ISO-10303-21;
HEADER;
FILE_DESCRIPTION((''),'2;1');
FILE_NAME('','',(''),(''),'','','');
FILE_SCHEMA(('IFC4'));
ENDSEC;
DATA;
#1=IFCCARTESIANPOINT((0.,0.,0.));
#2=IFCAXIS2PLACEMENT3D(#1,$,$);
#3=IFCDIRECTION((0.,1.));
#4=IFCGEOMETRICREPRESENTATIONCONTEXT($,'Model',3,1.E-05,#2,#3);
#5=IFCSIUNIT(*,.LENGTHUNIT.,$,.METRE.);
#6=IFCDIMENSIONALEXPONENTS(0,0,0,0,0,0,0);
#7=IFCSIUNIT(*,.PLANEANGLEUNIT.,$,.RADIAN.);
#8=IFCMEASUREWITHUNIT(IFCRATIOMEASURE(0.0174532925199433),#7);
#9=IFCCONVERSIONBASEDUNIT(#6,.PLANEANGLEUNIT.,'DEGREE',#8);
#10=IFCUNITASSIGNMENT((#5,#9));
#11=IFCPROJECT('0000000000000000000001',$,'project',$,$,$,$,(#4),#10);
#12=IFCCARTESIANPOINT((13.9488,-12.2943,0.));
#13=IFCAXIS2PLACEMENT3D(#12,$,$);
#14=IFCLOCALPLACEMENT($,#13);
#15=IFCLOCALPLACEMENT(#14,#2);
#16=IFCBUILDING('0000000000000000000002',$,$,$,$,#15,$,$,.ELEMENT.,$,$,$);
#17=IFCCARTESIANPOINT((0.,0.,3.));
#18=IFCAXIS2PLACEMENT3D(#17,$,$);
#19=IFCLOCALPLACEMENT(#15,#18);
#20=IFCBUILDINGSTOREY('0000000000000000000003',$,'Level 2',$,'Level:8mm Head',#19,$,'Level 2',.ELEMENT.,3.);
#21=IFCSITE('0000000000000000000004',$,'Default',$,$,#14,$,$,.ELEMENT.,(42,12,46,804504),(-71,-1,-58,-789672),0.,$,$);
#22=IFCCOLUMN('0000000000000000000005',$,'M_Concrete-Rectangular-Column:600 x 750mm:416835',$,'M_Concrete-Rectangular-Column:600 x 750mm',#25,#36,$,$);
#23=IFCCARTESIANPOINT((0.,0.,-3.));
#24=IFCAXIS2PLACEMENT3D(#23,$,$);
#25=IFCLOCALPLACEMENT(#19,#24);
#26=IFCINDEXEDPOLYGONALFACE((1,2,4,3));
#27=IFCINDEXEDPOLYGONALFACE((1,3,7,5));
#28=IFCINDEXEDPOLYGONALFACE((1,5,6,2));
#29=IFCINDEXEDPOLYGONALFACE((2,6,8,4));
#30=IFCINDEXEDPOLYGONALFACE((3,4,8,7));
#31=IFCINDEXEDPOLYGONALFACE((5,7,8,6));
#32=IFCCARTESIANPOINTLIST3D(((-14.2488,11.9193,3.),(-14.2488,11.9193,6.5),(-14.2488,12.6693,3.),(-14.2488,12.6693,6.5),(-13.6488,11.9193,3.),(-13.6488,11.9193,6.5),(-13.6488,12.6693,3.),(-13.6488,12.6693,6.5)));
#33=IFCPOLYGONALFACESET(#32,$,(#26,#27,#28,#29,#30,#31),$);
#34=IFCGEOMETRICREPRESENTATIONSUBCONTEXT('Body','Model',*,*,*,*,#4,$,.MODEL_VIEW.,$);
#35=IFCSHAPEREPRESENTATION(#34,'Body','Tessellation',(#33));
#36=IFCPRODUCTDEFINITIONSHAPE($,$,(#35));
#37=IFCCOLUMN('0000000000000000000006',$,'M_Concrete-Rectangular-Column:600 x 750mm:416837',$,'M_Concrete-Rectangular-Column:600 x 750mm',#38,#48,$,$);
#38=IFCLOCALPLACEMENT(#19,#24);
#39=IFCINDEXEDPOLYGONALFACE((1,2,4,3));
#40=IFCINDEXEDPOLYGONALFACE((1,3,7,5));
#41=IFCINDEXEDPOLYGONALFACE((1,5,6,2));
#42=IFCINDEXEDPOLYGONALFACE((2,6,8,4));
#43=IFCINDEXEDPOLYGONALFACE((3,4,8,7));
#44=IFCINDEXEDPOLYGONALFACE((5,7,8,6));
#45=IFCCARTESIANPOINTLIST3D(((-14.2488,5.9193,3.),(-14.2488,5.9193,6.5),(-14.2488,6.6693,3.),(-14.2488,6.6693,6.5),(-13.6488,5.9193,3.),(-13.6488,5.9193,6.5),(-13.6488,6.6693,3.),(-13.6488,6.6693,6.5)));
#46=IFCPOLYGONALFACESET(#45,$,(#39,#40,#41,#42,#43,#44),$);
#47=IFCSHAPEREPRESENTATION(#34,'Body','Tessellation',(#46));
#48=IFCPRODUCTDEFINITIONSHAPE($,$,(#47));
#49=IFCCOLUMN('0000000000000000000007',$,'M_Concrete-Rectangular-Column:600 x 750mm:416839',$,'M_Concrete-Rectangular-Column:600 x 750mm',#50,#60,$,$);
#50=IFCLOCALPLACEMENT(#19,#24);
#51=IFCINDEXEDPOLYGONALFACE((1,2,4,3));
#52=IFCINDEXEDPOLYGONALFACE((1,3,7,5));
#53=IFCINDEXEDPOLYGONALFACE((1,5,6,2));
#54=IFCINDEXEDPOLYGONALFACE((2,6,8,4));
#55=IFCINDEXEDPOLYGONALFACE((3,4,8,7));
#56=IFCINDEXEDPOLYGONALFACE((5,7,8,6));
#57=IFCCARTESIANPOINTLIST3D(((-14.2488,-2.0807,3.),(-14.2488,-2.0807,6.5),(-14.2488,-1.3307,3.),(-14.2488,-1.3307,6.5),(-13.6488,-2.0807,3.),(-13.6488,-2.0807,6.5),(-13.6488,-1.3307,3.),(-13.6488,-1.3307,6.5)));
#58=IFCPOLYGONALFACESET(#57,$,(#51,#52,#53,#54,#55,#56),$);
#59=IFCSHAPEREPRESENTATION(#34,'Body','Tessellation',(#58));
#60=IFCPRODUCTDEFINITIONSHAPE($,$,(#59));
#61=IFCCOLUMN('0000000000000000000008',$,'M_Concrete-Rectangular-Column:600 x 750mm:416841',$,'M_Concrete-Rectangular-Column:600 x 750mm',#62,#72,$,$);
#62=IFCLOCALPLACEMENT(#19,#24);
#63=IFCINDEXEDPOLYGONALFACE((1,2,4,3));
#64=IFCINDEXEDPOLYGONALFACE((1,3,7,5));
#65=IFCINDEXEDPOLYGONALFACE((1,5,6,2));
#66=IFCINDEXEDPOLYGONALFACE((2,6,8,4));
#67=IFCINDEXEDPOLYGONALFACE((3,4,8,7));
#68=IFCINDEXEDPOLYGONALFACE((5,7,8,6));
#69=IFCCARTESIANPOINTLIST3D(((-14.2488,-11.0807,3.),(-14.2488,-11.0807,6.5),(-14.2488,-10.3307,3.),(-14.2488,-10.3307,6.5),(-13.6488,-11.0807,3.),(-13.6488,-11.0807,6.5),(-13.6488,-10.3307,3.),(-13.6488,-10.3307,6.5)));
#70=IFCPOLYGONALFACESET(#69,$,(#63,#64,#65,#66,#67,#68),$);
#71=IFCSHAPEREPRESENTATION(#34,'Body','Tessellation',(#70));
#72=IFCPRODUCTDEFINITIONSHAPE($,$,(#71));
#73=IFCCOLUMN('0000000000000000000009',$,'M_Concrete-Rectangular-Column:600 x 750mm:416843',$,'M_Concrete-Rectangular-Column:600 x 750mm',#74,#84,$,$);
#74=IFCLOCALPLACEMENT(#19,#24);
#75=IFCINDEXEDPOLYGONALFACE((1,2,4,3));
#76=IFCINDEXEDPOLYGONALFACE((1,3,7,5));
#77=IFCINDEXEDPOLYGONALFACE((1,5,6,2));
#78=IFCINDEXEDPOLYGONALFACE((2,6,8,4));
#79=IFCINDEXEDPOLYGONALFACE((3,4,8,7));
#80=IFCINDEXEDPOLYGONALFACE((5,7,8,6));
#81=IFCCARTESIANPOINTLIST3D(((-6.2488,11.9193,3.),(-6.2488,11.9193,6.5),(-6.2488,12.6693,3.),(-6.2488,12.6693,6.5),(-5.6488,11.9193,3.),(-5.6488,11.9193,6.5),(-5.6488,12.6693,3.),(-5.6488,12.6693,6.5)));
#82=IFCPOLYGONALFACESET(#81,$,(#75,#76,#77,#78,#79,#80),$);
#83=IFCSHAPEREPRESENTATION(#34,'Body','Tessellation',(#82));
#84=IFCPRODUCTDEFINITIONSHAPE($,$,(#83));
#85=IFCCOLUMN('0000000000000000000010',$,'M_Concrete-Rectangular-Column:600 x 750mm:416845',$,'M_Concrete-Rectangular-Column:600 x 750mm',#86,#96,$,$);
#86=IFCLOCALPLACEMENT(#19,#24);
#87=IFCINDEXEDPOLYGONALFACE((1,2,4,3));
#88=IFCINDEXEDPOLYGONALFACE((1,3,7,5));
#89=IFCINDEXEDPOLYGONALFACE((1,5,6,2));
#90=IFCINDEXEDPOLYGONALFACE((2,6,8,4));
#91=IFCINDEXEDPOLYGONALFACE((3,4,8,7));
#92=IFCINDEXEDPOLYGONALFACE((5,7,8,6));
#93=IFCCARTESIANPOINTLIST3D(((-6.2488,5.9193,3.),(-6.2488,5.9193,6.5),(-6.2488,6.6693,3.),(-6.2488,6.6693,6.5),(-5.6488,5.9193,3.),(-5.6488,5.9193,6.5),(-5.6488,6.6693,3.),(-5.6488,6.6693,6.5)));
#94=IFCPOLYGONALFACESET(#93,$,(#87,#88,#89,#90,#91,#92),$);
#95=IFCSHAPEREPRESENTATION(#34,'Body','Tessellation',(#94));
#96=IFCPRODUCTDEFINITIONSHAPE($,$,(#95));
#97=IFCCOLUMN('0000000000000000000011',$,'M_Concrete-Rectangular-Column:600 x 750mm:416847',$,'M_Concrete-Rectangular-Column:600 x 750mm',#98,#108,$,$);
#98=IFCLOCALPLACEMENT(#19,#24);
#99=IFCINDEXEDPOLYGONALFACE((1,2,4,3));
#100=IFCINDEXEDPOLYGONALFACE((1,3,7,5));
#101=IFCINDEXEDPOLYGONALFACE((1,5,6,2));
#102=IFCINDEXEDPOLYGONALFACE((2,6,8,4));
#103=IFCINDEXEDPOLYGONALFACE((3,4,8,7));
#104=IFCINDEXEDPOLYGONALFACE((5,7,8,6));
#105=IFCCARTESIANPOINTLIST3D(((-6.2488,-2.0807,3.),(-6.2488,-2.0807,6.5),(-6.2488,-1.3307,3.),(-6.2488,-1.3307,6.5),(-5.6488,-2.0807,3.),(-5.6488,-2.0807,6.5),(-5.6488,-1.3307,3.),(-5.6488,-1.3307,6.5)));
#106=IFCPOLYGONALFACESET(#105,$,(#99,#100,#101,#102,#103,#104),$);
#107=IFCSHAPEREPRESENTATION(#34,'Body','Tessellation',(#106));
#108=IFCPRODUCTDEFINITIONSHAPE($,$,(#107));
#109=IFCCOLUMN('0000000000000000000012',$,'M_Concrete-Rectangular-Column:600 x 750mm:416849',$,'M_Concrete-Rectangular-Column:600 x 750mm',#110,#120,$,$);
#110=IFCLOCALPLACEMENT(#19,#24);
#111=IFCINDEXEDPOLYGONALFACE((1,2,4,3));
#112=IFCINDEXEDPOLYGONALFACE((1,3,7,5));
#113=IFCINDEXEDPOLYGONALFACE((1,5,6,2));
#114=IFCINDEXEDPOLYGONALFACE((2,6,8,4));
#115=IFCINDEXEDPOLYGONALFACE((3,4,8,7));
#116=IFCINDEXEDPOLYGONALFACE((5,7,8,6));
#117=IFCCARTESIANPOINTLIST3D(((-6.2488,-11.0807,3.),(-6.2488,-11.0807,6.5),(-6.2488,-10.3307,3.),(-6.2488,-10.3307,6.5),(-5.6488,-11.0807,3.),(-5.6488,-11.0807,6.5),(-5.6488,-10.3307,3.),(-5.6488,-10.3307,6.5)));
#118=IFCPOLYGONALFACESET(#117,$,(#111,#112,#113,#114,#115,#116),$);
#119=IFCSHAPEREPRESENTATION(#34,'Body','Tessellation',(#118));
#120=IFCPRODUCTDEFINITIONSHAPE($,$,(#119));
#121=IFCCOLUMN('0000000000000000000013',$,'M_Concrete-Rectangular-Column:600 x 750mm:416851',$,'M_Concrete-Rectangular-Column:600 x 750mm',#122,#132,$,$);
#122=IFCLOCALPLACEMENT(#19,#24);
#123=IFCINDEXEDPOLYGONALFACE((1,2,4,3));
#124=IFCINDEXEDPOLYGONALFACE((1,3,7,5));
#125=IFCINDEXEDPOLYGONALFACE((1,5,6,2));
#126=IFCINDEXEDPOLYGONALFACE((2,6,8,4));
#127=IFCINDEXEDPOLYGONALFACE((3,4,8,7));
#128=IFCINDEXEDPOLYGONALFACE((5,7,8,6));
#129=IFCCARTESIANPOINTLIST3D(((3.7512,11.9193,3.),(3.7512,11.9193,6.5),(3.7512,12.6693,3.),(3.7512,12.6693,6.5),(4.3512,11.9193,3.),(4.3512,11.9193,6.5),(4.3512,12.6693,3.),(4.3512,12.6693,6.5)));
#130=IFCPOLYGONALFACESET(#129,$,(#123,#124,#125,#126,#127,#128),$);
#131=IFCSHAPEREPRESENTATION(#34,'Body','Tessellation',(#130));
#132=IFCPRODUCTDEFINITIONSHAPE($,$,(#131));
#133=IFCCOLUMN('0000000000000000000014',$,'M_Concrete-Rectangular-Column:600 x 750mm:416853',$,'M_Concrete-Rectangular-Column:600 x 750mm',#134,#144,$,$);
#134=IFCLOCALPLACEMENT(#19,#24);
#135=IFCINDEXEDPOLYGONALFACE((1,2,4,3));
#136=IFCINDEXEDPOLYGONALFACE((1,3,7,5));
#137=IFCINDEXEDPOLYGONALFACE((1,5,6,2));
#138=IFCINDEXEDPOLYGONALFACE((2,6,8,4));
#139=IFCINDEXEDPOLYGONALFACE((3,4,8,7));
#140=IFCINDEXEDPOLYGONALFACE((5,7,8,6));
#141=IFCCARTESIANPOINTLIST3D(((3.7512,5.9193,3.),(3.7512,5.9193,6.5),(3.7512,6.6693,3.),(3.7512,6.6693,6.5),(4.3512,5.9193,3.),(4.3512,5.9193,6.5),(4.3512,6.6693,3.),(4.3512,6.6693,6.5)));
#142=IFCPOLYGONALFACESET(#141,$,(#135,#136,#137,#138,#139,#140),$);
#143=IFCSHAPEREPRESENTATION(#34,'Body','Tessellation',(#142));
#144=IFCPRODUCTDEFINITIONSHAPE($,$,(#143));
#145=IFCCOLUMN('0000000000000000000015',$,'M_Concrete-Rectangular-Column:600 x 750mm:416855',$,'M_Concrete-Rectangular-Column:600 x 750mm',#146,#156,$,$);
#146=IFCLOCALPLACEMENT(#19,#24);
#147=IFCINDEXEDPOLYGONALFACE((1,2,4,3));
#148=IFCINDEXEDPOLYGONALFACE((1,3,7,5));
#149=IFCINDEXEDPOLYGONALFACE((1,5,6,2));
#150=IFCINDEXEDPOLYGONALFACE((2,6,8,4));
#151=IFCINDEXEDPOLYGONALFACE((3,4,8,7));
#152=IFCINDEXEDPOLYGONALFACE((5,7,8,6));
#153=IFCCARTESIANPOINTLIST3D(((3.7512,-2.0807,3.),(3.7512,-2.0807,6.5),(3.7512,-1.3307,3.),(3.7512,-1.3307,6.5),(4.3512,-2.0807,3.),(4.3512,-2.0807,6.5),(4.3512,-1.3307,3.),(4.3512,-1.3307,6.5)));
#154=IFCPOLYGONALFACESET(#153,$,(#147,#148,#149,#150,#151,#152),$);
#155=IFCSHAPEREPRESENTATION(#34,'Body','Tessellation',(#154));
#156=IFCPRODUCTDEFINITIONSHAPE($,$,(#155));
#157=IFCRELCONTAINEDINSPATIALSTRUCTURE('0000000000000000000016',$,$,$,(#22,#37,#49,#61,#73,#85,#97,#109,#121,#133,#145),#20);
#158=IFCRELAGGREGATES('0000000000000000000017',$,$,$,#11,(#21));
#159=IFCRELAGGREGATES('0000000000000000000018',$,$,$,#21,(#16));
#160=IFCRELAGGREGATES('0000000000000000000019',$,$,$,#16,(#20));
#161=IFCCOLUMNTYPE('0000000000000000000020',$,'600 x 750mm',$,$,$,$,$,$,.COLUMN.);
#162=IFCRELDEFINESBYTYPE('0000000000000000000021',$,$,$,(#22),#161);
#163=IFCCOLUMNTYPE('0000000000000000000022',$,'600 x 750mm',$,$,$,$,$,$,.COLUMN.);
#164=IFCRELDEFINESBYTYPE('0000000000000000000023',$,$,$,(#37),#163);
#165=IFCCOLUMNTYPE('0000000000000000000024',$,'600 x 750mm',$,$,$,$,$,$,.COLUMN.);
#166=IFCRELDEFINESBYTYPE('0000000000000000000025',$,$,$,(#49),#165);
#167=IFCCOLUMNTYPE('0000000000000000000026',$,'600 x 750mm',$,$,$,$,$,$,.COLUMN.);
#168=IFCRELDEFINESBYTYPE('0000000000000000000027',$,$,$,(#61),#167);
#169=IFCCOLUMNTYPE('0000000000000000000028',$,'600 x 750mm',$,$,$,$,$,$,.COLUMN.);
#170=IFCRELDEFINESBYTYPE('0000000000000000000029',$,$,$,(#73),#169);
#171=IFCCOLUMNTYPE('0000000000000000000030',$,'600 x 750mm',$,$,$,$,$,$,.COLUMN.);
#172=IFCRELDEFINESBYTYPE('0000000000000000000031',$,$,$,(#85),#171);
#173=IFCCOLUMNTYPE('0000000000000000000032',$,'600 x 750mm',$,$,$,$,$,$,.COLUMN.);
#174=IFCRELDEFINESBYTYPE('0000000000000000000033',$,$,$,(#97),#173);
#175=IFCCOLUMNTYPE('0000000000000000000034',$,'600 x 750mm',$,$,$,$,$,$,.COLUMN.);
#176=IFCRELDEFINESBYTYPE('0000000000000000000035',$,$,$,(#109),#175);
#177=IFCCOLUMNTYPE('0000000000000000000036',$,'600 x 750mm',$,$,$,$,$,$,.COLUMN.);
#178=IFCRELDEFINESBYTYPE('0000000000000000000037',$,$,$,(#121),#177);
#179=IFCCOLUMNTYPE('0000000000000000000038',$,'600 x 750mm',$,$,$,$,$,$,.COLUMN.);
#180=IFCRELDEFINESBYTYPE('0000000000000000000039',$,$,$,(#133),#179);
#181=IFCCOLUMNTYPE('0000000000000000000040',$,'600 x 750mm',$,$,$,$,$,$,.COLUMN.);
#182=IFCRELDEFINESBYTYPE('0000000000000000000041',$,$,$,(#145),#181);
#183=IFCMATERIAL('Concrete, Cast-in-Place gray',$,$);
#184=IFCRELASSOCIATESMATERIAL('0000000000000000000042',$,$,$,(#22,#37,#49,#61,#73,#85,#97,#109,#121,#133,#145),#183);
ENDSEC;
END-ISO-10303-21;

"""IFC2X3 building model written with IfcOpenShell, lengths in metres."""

from ifc_helpers import new_model, entity, si_unit, converted_unit, direction, frame, frame_2d, origin, origin_2d_with_axis, place, context, subcontext, project, spatial, rectangle, extrude, source, transform, mapped, material, type_object, type_shapes, element, save


model = new_model("IFC2X3")

# Units and contexts
model_context = context("Model", 3, precision=1e-05, world=origin(), true_north=direction((0.0, 1.0)))
body_context = subcontext(model_context, "Body", "Model", "MODEL_VIEW")
ifc_project = project(units=[si_unit("LENGTHUNIT", "METRE"), converted_unit("PLANEANGLEUNIT", "DEGREE", entity("IfcRatioMeasure", 0.0174532925199433), si_unit("PLANEANGLEUNIT", "RADIAN"), dimensions=[0, 0, 0, 0, 0, 0, 0])], contexts=[model_context])

# Site, building, storey
site_placement = place(None, frame((13.9488, -12.2943, 0.0)))
site = spatial("IfcSite", under=ifc_project, at=site_placement, Name="Default", CompositionType="ELEMENT", RefLatitude=(42, 12, 46, 804504), RefLongitude=(-71, -1, -58, -789672), RefElevation=0.0)
building_placement = place(site_placement, origin())
building = spatial("IfcBuilding", under=site, at=building_placement, CompositionType="ELEMENT")
storey_placement = place(building_placement, frame((0.0, 0.0, 3.0)))
storey = spatial("IfcBuildingStorey", under=building, at=storey_placement, Name="Level 2", ObjectType="Level:8mm Head", LongName="Level 2", CompositionType="ELEMENT", Elevation=3.0)

# Columns
ifc_material = material(Name="Concrete, Cast-in-Place gray")
column_type_1 = type_object("IfcColumnType", Name="600 x 750mm", PredefinedType="COLUMN")
shared_shape_1 = source(origin(), body_context, "Body", "SweptSolid", [
    extrude(rectangle(XDim=0.75, YDim=0.6, at=frame_2d((0.0, 0.0), x_axis=(1.0, 0.0))), frame((-13.9488, 12.2943, 3.0), z_axis=(0.0, 0.0, 1.0), x_axis=(0.0, -1.0, 0.0)), (0.0, 0.0, 1.0), 3.5),
])
type_shapes(column_type_1, [shared_shape_1])
column_1_placement = place(storey_placement, frame((0.0, 0.0, -3.0)))
element("IfcColumn", 1, at=column_1_placement, inside=storey, type_object=column_type_1, material=ifc_material, Name="M_Concrete-Rectangular-Column:600 x 750mm:416835", ObjectType="M_Concrete-Rectangular-Column:600 x 750mm", context=body_context, shape_type="MappedRepresentation", body=[
    mapped(shared_shape_1, transform((0.0, 0.0, 0.0), scale=1.0)),
])
column_type_2 = type_object("IfcColumnType", Name="600 x 750mm", PredefinedType="COLUMN")
shared_shape_2 = source(origin(), body_context, "Body", "SweptSolid", [
    extrude(rectangle(XDim=0.75, YDim=0.6, at=frame_2d((0.0, 0.0), x_axis=(1.0, 0.0))), frame((-13.9488, 6.2943, 3.0), z_axis=(0.0, 0.0, 1.0), x_axis=(0.0, -1.0, 0.0)), (0.0, 0.0, 1.0), 3.5),
])
type_shapes(column_type_2, [shared_shape_2])
column_2_placement = place(storey_placement, frame((0.0, 0.0, -3.0)))
element("IfcColumn", 2, at=column_2_placement, inside=storey, type_object=column_type_2, material=ifc_material, Name="M_Concrete-Rectangular-Column:600 x 750mm:416837", ObjectType="M_Concrete-Rectangular-Column:600 x 750mm", context=body_context, shape_type="MappedRepresentation", body=[
    mapped(shared_shape_2, transform((0.0, 0.0, 0.0), scale=1.0)),
])
column_type_3 = type_object("IfcColumnType", Name="600 x 750mm", PredefinedType="COLUMN")
shared_shape_3 = source(origin(), body_context, "Body", "SweptSolid", [
    extrude(rectangle(XDim=0.75, YDim=0.6, at=frame_2d((0.0, 0.0), x_axis=(1.0, 0.0))), frame((-13.9488, -1.7057, 3.0), z_axis=(0.0, 0.0, 1.0), x_axis=(0.0, -1.0, 0.0)), (0.0, 0.0, 1.0), 3.5),
])
type_shapes(column_type_3, [shared_shape_3])
column_3_placement = place(storey_placement, frame((0.0, 0.0, -3.0)))
element("IfcColumn", 3, at=column_3_placement, inside=storey, type_object=column_type_3, material=ifc_material, Name="M_Concrete-Rectangular-Column:600 x 750mm:416839", ObjectType="M_Concrete-Rectangular-Column:600 x 750mm", context=body_context, shape_type="MappedRepresentation", body=[
    mapped(shared_shape_3, transform((0.0, 0.0, 0.0), scale=1.0)),
])
column_type_4 = type_object("IfcColumnType", Name="600 x 750mm", PredefinedType="COLUMN")
shared_shape_4 = source(origin(), body_context, "Body", "SweptSolid", [
    extrude(rectangle(XDim=0.75, YDim=0.6, at=frame_2d((0.0, 0.0), x_axis=(1.0, 0.0))), frame((-13.9488, -10.7057, 3.0), z_axis=(0.0, 0.0, 1.0), x_axis=(0.0, -1.0, 0.0)), (0.0, 0.0, 1.0), 3.5),
])
type_shapes(column_type_4, [shared_shape_4])
column_4_placement = place(storey_placement, frame((0.0, 0.0, -3.0)))
element("IfcColumn", 4, at=column_4_placement, inside=storey, type_object=column_type_4, material=ifc_material, Name="M_Concrete-Rectangular-Column:600 x 750mm:416841", ObjectType="M_Concrete-Rectangular-Column:600 x 750mm", context=body_context, shape_type="MappedRepresentation", body=[
    mapped(shared_shape_4, transform((0.0, 0.0, 0.0), scale=1.0)),
])
column_type_5 = type_object("IfcColumnType", Name="600 x 750mm", PredefinedType="COLUMN")
shared_shape_5 = source(origin(), body_context, "Body", "SweptSolid", [
    extrude(rectangle(XDim=0.75, YDim=0.6, at=origin_2d_with_axis()), frame((-5.9488, 12.2943, 3.0), z_axis=(0.0, 0.0, 1.0), x_axis=(0.0, -1.0, 0.0)), (0.0, 0.0, 1.0), 3.5),
])
type_shapes(column_type_5, [shared_shape_5])
column_5_placement = place(storey_placement, frame((0.0, 0.0, -3.0)))
element("IfcColumn", 5, at=column_5_placement, inside=storey, type_object=column_type_5, material=ifc_material, Name="M_Concrete-Rectangular-Column:600 x 750mm:416843", ObjectType="M_Concrete-Rectangular-Column:600 x 750mm", context=body_context, shape_type="MappedRepresentation", body=[
    mapped(shared_shape_5, transform((0.0, 0.0, 0.0), scale=1.0)),
])
column_type_6 = type_object("IfcColumnType", Name="600 x 750mm", PredefinedType="COLUMN")
shared_shape_6 = source(origin(), body_context, "Body", "SweptSolid", [
    extrude(rectangle(XDim=0.75, YDim=0.6, at=origin_2d_with_axis()), frame((-5.9488, 6.2943, 3.0), z_axis=(0.0, 0.0, 1.0), x_axis=(0.0, -1.0, 0.0)), (0.0, 0.0, 1.0), 3.5),
])
type_shapes(column_type_6, [shared_shape_6])
column_6_placement = place(storey_placement, frame((0.0, 0.0, -3.0)))
element("IfcColumn", 6, at=column_6_placement, inside=storey, type_object=column_type_6, material=ifc_material, Name="M_Concrete-Rectangular-Column:600 x 750mm:416845", ObjectType="M_Concrete-Rectangular-Column:600 x 750mm", context=body_context, shape_type="MappedRepresentation", body=[
    mapped(shared_shape_6, transform((0.0, 0.0, 0.0), scale=1.0)),
])
column_type_7 = type_object("IfcColumnType", Name="600 x 750mm", PredefinedType="COLUMN")
shared_shape_7 = source(origin(), body_context, "Body", "SweptSolid", [
    extrude(rectangle(XDim=0.75, YDim=0.6, at=frame_2d((0.0, 0.0), x_axis=(1.0, 0.0))), frame((-5.9488, -1.7057, 3.0), z_axis=(0.0, 0.0, 1.0), x_axis=(0.0, -1.0, 0.0)), (0.0, 0.0, 1.0), 3.5),
])
type_shapes(column_type_7, [shared_shape_7])
column_7_placement = place(storey_placement, frame((0.0, 0.0, -3.0)))
element("IfcColumn", 7, at=column_7_placement, inside=storey, type_object=column_type_7, material=ifc_material, Name="M_Concrete-Rectangular-Column:600 x 750mm:416847", ObjectType="M_Concrete-Rectangular-Column:600 x 750mm", context=body_context, shape_type="MappedRepresentation", body=[
    mapped(shared_shape_7, transform((0.0, 0.0, 0.0), scale=1.0)),
])
column_type_8 = type_object("IfcColumnType", Name="600 x 750mm", PredefinedType="COLUMN")
shared_shape_8 = source(origin(), body_context, "Body", "SweptSolid", [
    extrude(rectangle(XDim=0.75, YDim=0.6, at=origin_2d_with_axis()), frame((-5.9488, -10.7057, 3.0), z_axis=(0.0, 0.0, 1.0), x_axis=(0.0, -1.0, 0.0)), (0.0, 0.0, 1.0), 3.5),
])
type_shapes(column_type_8, [shared_shape_8])
column_8_placement = place(storey_placement, frame((0.0, 0.0, -3.0)))
element("IfcColumn", 8, at=column_8_placement, inside=storey, type_object=column_type_8, material=ifc_material, Name="M_Concrete-Rectangular-Column:600 x 750mm:416849", ObjectType="M_Concrete-Rectangular-Column:600 x 750mm", context=body_context, shape_type="MappedRepresentation", body=[
    mapped(shared_shape_8, transform((0.0, 0.0, 0.0), scale=1.0)),
])
column_type_9 = type_object("IfcColumnType", Name="600 x 750mm", PredefinedType="COLUMN")
shared_shape_9 = source(origin(), body_context, "Body", "SweptSolid", [
    extrude(rectangle(XDim=0.75, YDim=0.6, at=origin_2d_with_axis()), frame((4.0512, 12.2943, 3.0), z_axis=(0.0, 0.0, 1.0), x_axis=(0.0, -1.0, 0.0)), (0.0, 0.0, 1.0), 3.5),
])
type_shapes(column_type_9, [shared_shape_9])
column_9_placement = place(storey_placement, frame((0.0, 0.0, -3.0)))
element("IfcColumn", 9, at=column_9_placement, inside=storey, type_object=column_type_9, material=ifc_material, Name="M_Concrete-Rectangular-Column:600 x 750mm:416851", ObjectType="M_Concrete-Rectangular-Column:600 x 750mm", context=body_context, shape_type="MappedRepresentation", body=[
    mapped(shared_shape_9, transform((0.0, 0.0, 0.0), scale=1.0)),
])
column_type_10 = type_object("IfcColumnType", Name="600 x 750mm", PredefinedType="COLUMN")
shared_shape_10 = source(origin(), body_context, "Body", "SweptSolid", [
    extrude(rectangle(XDim=0.75, YDim=0.6, at=origin_2d_with_axis()), frame((4.0512, 6.2943, 3.0), z_axis=(0.0, 0.0, 1.0), x_axis=(0.0, -1.0, 0.0)), (0.0, 0.0, 1.0), 3.5),
])
type_shapes(column_type_10, [shared_shape_10])
column_10_placement = place(storey_placement, frame((0.0, 0.0, -3.0)))
element("IfcColumn", 10, at=column_10_placement, inside=storey, type_object=column_type_10, material=ifc_material, Name="M_Concrete-Rectangular-Column:600 x 750mm:416853", ObjectType="M_Concrete-Rectangular-Column:600 x 750mm", context=body_context, shape_type="MappedRepresentation", body=[
    mapped(shared_shape_10, transform((0.0, 0.0, 0.0), scale=1.0)),
])
column_type_11 = type_object("IfcColumnType", Name="600 x 750mm", PredefinedType="COLUMN")
shared_shape_11 = source(origin(), body_context, "Body", "SweptSolid", [
    extrude(rectangle(XDim=0.75, YDim=0.6, at=frame_2d((0.0, 0.0), x_axis=(1.0, 0.0))), frame((4.0512, -1.7057, 3.0), z_axis=(0.0, 0.0, 1.0), x_axis=(0.0, -1.0, 0.0)), (0.0, 0.0, 1.0), 3.5),
])
type_shapes(column_type_11, [shared_shape_11])
column_11_placement = place(storey_placement, frame((0.0, 0.0, -3.0)))
element("IfcColumn", 11, at=column_11_placement, inside=storey, type_object=column_type_11, material=ifc_material, Name="M_Concrete-Rectangular-Column:600 x 750mm:416855", ObjectType="M_Concrete-Rectangular-Column:600 x 750mm", context=body_context, shape_type="MappedRepresentation", body=[
    mapped(shared_shape_11, transform((0.0, 0.0, 0.0), scale=1.0)),
])

save(model, "model.ifc")
